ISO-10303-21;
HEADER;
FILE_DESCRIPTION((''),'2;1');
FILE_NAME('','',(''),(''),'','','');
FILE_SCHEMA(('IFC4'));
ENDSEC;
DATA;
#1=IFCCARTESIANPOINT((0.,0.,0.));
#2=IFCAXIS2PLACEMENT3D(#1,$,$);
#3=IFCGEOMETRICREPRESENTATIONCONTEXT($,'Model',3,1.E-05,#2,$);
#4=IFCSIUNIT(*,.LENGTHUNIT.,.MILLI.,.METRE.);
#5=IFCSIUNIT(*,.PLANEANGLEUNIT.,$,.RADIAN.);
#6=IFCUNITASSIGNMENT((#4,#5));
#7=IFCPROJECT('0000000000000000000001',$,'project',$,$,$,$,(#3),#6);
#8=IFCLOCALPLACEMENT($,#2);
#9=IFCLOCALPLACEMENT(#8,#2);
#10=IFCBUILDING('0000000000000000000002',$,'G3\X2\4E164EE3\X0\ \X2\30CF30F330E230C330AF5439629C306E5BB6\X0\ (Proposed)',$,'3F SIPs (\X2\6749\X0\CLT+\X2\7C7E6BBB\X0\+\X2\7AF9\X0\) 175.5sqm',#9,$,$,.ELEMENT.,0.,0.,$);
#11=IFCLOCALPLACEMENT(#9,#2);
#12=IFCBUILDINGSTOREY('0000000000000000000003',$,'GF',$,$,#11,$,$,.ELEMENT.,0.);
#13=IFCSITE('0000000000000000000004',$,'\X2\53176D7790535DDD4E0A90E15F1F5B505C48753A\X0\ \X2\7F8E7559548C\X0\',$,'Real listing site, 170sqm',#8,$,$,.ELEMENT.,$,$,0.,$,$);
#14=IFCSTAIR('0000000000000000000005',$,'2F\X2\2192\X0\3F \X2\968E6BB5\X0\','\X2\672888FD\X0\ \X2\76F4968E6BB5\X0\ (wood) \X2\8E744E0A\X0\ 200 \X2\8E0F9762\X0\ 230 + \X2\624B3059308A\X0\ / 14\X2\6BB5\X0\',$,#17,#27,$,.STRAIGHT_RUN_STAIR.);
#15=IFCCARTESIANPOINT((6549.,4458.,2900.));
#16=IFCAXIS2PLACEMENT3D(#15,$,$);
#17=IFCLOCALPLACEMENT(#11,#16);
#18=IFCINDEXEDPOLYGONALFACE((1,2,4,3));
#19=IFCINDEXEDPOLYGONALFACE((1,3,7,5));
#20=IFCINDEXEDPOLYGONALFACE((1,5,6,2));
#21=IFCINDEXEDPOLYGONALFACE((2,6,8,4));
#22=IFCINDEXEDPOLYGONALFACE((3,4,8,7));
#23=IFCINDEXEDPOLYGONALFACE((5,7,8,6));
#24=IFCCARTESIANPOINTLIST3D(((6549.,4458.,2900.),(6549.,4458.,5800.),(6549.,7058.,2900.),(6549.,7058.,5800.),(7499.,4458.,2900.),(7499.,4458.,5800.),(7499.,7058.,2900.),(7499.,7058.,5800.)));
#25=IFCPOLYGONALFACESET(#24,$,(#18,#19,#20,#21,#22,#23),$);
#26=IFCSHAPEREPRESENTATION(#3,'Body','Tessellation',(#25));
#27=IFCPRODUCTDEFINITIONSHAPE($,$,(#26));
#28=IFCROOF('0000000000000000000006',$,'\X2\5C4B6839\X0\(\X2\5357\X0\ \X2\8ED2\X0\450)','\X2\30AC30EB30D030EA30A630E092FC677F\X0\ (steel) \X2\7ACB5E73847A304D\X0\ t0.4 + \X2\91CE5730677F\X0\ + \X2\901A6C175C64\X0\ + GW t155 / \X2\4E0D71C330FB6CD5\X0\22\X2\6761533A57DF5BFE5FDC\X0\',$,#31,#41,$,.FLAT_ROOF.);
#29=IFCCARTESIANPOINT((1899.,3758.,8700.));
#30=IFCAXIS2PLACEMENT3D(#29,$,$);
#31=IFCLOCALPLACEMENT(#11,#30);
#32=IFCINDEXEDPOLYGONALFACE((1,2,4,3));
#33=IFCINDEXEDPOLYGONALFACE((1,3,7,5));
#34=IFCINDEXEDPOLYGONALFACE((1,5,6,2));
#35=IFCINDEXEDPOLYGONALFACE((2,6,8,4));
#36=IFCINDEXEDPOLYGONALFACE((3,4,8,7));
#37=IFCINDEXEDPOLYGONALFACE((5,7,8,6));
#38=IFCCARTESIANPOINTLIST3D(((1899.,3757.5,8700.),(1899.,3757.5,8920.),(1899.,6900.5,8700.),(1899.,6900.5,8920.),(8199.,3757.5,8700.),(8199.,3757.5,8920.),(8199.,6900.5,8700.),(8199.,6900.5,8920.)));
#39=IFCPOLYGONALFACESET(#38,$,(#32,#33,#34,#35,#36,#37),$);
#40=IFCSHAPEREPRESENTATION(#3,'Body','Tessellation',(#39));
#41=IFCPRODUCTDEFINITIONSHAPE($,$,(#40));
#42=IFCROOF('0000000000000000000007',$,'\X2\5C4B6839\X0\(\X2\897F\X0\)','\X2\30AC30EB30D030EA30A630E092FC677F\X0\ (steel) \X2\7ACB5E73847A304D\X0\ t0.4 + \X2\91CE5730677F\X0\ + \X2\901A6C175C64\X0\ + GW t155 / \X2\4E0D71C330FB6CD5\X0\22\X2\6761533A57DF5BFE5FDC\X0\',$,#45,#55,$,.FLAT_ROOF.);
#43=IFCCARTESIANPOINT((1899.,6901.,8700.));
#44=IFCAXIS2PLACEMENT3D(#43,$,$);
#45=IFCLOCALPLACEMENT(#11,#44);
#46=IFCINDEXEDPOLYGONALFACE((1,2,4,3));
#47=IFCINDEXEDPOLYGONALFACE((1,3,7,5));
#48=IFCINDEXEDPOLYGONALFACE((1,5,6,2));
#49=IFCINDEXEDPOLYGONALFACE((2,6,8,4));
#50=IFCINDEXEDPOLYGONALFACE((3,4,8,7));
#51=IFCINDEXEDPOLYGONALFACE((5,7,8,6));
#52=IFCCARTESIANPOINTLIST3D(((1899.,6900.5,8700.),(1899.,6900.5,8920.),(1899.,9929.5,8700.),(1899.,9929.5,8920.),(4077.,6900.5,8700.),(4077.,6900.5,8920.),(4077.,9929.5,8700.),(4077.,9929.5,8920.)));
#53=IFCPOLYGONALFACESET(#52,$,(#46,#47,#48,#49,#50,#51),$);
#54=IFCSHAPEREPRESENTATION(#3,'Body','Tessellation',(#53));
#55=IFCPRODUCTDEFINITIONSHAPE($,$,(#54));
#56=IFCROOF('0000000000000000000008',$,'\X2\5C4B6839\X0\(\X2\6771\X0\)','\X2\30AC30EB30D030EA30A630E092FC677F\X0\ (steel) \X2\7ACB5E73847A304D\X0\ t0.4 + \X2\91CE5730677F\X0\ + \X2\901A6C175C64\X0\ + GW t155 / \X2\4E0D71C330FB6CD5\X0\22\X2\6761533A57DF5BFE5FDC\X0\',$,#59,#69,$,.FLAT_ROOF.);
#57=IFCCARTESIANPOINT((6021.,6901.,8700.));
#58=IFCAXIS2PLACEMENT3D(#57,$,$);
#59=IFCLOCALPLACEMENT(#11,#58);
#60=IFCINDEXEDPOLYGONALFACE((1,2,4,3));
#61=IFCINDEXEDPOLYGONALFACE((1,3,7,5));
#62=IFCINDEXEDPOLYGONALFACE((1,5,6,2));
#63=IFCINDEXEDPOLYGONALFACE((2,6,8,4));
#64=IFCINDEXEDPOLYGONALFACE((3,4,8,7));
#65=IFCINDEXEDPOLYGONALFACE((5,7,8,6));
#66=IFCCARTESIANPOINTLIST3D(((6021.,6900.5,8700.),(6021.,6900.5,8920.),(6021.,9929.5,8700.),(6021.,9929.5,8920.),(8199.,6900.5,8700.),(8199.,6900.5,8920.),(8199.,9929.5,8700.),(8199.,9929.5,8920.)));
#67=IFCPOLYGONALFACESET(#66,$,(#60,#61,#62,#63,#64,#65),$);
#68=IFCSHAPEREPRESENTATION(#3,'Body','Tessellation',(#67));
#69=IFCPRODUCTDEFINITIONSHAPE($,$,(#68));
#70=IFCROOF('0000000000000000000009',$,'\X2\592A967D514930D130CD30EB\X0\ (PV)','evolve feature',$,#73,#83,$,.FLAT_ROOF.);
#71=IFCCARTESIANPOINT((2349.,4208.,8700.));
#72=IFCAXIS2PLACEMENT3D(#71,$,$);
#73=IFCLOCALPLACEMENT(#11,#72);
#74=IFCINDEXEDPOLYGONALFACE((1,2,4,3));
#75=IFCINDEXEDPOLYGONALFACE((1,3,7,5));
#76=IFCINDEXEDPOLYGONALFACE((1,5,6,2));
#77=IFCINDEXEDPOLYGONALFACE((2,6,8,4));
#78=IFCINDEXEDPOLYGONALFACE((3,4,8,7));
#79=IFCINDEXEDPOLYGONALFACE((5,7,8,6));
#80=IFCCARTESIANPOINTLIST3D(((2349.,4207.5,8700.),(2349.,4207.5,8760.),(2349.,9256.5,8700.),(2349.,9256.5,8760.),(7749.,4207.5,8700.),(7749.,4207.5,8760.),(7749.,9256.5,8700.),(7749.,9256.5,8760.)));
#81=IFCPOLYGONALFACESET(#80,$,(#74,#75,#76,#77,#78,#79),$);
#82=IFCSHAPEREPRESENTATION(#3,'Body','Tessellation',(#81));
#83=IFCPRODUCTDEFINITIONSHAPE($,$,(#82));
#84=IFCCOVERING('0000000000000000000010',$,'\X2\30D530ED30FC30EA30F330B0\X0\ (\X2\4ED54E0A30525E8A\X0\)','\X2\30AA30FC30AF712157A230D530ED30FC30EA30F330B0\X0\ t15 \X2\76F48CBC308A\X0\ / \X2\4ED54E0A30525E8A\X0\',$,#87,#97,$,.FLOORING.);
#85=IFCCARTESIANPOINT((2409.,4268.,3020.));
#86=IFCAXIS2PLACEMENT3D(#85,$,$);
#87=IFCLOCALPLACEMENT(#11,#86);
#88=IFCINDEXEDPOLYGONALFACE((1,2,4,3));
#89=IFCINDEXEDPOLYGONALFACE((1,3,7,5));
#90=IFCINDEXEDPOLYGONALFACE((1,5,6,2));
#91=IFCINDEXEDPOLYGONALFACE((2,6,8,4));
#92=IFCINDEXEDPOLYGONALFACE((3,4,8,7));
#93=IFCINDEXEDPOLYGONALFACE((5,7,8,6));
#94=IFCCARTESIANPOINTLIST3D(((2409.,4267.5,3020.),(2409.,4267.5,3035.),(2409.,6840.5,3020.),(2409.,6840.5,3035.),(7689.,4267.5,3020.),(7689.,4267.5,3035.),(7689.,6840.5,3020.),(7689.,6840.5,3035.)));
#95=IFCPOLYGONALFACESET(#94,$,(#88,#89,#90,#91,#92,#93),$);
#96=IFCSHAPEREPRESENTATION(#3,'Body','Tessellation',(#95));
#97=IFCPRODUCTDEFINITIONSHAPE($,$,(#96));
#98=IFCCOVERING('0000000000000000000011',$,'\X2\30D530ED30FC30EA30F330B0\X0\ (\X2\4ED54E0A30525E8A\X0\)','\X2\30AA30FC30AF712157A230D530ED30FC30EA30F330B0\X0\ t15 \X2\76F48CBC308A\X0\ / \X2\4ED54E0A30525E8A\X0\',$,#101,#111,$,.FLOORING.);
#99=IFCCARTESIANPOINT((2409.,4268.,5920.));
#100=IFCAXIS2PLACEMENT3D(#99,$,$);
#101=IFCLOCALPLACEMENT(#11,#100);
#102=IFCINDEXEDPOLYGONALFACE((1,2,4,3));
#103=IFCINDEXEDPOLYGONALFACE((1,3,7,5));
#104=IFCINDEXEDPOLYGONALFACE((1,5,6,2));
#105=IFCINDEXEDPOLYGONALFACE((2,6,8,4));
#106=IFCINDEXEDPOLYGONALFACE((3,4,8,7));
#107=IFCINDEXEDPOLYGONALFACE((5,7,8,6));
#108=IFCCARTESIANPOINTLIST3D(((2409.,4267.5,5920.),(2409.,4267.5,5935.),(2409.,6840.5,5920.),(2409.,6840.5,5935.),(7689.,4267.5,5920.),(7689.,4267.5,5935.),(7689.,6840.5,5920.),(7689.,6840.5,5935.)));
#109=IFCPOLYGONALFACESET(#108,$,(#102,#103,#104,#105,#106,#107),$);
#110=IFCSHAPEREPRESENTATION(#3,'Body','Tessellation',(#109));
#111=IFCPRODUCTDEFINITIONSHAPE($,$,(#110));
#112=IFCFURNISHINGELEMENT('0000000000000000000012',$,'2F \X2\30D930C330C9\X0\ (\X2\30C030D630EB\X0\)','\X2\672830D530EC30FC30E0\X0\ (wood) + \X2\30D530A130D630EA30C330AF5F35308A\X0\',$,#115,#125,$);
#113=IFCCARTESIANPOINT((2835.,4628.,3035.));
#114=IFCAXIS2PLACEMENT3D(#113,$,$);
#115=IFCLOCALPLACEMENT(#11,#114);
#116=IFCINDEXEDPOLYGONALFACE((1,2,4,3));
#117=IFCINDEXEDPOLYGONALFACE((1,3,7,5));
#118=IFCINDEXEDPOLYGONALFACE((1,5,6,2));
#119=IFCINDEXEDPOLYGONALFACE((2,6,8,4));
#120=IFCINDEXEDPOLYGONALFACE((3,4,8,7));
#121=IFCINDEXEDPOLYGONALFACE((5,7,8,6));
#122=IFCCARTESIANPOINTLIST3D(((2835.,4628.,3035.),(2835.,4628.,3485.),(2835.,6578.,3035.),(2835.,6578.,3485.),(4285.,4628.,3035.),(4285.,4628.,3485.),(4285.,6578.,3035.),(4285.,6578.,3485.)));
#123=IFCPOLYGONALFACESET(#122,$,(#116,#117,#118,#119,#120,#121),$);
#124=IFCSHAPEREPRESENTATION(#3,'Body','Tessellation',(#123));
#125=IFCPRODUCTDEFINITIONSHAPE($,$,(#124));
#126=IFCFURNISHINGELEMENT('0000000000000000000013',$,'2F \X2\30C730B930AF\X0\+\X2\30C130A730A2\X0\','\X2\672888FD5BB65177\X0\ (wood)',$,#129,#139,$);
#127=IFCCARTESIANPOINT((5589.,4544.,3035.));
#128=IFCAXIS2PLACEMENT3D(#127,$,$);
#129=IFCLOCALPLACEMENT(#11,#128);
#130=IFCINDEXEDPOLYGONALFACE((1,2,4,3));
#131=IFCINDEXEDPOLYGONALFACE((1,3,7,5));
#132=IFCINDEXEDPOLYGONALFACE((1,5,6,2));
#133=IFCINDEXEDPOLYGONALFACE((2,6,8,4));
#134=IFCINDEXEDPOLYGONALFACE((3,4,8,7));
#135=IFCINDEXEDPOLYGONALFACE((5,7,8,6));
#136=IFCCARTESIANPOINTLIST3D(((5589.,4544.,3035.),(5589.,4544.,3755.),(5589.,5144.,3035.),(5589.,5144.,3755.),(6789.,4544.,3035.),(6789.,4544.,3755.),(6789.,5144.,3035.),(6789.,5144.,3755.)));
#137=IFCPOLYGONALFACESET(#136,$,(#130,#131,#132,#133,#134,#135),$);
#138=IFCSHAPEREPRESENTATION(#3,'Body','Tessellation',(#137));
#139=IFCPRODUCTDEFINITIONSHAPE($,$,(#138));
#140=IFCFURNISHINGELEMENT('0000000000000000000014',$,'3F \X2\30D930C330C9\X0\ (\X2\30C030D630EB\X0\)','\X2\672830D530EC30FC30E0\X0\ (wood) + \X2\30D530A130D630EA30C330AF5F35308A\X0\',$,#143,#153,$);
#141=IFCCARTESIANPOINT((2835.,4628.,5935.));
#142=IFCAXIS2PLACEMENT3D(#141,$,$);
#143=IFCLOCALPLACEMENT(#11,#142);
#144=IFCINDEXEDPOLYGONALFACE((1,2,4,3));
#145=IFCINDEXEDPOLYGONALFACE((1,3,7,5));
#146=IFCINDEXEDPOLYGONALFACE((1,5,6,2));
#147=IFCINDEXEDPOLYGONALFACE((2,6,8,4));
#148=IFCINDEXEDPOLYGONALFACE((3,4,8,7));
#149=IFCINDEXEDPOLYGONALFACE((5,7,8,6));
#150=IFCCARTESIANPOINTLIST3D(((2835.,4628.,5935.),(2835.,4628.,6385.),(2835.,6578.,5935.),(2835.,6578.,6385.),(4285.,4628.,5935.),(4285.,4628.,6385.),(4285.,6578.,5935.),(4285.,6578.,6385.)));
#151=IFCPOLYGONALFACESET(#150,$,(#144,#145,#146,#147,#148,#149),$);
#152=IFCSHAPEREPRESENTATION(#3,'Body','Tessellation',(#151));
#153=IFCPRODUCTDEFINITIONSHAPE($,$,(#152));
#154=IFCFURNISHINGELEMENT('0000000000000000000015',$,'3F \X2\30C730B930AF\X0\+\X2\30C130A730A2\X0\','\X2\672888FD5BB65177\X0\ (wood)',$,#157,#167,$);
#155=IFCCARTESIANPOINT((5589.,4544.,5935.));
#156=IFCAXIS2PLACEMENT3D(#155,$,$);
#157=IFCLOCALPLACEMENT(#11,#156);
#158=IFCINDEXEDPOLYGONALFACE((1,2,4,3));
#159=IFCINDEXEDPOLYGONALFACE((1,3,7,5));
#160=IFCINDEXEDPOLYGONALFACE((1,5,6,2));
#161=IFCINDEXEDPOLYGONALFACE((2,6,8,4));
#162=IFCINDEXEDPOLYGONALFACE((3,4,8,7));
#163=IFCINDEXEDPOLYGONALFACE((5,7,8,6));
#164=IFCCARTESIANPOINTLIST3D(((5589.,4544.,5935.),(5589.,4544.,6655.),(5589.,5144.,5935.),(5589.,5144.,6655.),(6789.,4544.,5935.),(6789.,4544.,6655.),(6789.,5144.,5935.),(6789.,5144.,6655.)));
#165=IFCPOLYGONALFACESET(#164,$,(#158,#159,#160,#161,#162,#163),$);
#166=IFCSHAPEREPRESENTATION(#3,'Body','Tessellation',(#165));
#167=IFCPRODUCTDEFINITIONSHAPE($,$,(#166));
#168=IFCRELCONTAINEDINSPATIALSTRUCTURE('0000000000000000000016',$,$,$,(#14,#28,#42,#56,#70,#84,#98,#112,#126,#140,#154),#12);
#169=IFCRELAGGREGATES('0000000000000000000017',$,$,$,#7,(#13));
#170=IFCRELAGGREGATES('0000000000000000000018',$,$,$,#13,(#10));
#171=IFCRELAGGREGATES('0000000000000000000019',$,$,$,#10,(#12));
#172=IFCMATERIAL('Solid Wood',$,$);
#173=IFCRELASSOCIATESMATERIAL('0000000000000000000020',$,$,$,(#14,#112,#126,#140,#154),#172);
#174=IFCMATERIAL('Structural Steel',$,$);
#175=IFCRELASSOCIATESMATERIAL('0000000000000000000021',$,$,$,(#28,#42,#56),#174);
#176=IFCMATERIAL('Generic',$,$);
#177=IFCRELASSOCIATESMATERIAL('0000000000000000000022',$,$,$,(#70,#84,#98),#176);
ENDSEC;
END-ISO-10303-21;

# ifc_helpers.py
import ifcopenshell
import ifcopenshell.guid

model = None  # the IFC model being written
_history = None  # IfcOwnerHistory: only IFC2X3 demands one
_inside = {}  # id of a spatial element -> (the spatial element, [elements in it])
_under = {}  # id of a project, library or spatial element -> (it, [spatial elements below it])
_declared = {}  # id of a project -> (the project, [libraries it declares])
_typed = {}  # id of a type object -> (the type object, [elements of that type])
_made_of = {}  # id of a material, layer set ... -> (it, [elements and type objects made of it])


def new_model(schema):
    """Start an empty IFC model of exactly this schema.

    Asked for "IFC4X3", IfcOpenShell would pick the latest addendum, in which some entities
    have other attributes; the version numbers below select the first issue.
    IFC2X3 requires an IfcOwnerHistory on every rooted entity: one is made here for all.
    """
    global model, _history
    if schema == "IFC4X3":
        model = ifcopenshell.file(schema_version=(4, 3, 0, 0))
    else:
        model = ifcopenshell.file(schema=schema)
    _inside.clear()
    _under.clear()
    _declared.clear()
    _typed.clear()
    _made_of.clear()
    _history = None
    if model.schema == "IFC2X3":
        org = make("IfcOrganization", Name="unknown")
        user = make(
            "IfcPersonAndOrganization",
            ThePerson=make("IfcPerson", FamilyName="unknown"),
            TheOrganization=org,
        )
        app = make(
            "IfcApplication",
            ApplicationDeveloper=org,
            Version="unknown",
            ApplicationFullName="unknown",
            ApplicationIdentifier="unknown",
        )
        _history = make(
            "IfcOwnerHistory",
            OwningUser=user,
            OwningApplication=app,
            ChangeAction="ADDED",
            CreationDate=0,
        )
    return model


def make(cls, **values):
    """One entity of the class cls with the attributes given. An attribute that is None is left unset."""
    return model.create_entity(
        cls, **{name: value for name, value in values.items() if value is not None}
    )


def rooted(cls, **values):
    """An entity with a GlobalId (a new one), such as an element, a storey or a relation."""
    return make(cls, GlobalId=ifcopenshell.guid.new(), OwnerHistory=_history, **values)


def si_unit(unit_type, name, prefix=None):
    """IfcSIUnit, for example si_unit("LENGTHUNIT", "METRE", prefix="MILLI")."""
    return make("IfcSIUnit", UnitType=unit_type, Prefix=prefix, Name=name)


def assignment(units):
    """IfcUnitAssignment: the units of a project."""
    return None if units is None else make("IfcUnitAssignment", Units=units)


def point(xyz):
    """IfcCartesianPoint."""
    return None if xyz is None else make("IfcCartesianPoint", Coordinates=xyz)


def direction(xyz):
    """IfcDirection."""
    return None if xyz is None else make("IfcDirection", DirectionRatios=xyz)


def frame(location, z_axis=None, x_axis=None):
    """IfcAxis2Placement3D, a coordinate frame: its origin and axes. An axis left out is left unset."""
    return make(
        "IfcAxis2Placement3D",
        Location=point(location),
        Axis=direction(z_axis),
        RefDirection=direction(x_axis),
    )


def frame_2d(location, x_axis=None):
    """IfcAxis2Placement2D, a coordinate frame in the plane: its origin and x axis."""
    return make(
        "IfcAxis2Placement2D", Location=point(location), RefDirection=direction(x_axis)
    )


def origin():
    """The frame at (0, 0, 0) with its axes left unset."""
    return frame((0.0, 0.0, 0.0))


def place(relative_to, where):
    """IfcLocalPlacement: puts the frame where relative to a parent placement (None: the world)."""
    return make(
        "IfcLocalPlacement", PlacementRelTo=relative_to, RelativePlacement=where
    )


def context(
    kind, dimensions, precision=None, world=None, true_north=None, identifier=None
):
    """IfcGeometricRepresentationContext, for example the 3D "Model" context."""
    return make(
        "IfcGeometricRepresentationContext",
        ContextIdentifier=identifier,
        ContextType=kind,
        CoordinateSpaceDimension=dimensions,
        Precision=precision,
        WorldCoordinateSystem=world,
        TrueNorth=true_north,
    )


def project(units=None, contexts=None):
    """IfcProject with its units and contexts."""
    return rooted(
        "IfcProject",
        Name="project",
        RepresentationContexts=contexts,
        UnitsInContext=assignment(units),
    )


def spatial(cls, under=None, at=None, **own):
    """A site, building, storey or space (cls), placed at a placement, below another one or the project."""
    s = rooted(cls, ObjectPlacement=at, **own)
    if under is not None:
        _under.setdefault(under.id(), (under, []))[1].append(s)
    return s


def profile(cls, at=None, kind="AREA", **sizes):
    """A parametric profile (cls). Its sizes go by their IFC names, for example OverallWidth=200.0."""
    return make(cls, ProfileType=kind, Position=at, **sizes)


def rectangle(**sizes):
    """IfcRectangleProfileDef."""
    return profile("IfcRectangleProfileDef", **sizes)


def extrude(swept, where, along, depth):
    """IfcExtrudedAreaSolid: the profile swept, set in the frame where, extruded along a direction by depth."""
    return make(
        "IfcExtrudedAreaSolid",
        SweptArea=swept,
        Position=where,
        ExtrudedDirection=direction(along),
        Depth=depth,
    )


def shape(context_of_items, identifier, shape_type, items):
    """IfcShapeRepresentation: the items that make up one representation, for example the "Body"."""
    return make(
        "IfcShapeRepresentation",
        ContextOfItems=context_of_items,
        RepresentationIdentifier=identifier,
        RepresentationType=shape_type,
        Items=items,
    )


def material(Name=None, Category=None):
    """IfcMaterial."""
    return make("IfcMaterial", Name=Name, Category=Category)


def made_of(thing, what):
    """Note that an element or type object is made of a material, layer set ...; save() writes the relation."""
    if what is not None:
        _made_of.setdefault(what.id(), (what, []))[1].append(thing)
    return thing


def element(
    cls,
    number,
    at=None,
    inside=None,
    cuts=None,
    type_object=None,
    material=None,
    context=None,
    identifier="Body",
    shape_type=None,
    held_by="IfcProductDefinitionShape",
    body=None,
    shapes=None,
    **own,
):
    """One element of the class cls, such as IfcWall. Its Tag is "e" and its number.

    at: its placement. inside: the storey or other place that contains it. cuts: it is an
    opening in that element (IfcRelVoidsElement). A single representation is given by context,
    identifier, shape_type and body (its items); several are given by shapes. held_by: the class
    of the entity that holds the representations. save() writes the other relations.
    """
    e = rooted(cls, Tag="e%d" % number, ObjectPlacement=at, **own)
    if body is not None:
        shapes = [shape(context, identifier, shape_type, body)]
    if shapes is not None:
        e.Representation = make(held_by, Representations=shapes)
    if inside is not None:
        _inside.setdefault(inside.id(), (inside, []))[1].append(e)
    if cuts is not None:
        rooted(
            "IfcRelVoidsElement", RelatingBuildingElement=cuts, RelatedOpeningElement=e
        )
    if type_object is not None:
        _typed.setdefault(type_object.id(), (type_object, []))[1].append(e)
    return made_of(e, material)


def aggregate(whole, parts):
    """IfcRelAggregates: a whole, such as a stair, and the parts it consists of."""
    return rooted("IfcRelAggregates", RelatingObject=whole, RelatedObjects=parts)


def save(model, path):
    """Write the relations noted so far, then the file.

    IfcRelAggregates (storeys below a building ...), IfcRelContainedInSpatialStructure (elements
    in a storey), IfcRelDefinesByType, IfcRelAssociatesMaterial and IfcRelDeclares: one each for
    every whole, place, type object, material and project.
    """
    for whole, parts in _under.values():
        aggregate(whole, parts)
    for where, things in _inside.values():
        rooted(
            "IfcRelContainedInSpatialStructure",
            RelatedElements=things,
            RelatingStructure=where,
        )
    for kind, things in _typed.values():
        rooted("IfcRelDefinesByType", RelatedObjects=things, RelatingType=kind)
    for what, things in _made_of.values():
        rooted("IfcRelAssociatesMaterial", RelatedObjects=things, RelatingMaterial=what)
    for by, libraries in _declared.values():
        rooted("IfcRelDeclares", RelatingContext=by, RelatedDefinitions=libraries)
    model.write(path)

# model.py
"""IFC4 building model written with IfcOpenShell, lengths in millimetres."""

from ifc_helpers import new_model, si_unit, frame, frame_2d, origin, place, context, project, spatial, rectangle, extrude, material, element, save


model = new_model("IFC4")

# Units and contexts
model_context = context("Model", 3, precision=1e-05, world=origin())
ifc_project = project(units=[si_unit("LENGTHUNIT", "METRE", prefix="MILLI"), si_unit("PLANEANGLEUNIT", "RADIAN")], contexts=[model_context])

# Site, building, storey
site_placement = place(None, origin())
site = spatial("IfcSite", under=ifc_project, at=site_placement, Name="北海道川上郡弟子屈町 美留和", ObjectType="Real listing site, 170sqm", CompositionType="ELEMENT", RefElevation=0.0)
building_placement = place(site_placement, origin())
building = spatial("IfcBuilding", under=site, at=building_placement, Name="G3世代 ハンモック吹抜の家 (Proposed)", ObjectType="3F SIPs (杉CLT+籾殻+竹) 175.5sqm", CompositionType="ELEMENT", ElevationOfRefHeight=0.0, ElevationOfTerrain=0.0)
storey_placement = place(building_placement, origin())
storey = spatial("IfcBuildingStorey", under=building, at=storey_placement, Name="GF", CompositionType="ELEMENT", Elevation=0.0)

# Shared definitions
ifc_material_1 = material(Name="Solid Wood")

# Stair
stair_placement = place(storey_placement, frame((6549.0, 4458.0, 2900.0)))
element("IfcStair", 1, at=stair_placement, inside=storey, material=ifc_material_1, Name="2F→3F 階段", Description="木製 直階段 (wood) 蹴上 200 踏面 230 + 手すり / 14段", PredefinedType="STRAIGHT_RUN_STAIR", context=model_context, shape_type="SweptSolid", body=[
    extrude(rectangle(XDim=950.0, YDim=2600.0, at=frame_2d((475.0, 1300.0))), frame((6549.0, 4458.0, 2900.0)), (0.0, 0.0, 1.0), 2900.0),
])

# Roofs
ifc_material_2 = material(Name="Structural Steel")
roof_1_placement = place(storey_placement, frame((1899.0, 3758.0, 8700.0)))
element("IfcRoof", 2, at=roof_1_placement, inside=storey, material=ifc_material_2, Name="屋根(南 軒450)", Description="ガルバリウム鋼板 (steel) 立平葺き t0.4 + 野地板 + 通気層 + GW t155 / 不燃・法22条区域対応", PredefinedType="FLAT_ROOF", context=model_context, shape_type="SweptSolid", body=[
    extrude(rectangle(XDim=6300.0, YDim=3143.0, at=frame_2d((3150.0, 1571.0))), frame((1899.0, 3758.0, 8700.0)), (0.0, 0.0, 1.0), 220.0),
])
roof_2_placement = place(storey_placement, frame((1899.0, 6901.0, 8700.0)))
element("IfcRoof", 3, at=roof_2_placement, inside=storey, material=ifc_material_2, Name="屋根(西)", Description="ガルバリウム鋼板 (steel) 立平葺き t0.4 + 野地板 + 通気層 + GW t155 / 不燃・法22条区域対応", PredefinedType="FLAT_ROOF", context=model_context, shape_type="SweptSolid", body=[
    extrude(rectangle(XDim=2178.0, YDim=3029.0, at=frame_2d((1089.0, 1514.0))), frame((1899.0, 6901.0, 8700.0)), (0.0, 0.0, 1.0), 220.0),
])
roof_3_placement = place(storey_placement, frame((6021.0, 6901.0, 8700.0)))
element("IfcRoof", 4, at=roof_3_placement, inside=storey, material=ifc_material_2, Name="屋根(東)", Description="ガルバリウム鋼板 (steel) 立平葺き t0.4 + 野地板 + 通気層 + GW t155 / 不燃・法22条区域対応", PredefinedType="FLAT_ROOF", context=model_context, shape_type="SweptSolid", body=[
    extrude(rectangle(XDim=2178.0, YDim=3029.0, at=frame_2d((1089.0, 1514.0))), frame((6021.0, 6901.0, 8700.0)), (0.0, 0.0, 1.0), 220.0),
])
ifc_material_3 = material(Name="Generic")
roof_4_placement = place(storey_placement, frame((2349.0, 4208.0, 8700.0)))
element("IfcRoof", 5, at=roof_4_placement, inside=storey, material=ifc_material_3, Name="太陽光パネル (PV)", Description="evolve feature", PredefinedType="FLAT_ROOF", context=model_context, shape_type="SweptSolid", body=[
    extrude(rectangle(XDim=5400.0, YDim=5049.0, at=frame_2d((2700.0, 2524.0))), frame((2349.0, 4208.0, 8700.0)), (0.0, 0.0, 1.0), 60.0),
])

# Coverings
covering_1_placement = place(storey_placement, frame((2409.0, 4268.0, 3020.0)))
element("IfcCovering", 6, at=covering_1_placement, inside=storey, material=ifc_material_3, Name="フローリング (仕上げ床)", Description="オーク無垢フローリング t15 直貼り / 仕上げ床", PredefinedType="FLOORING", context=model_context, shape_type="SweptSolid", body=[
    extrude(rectangle(XDim=5280.0, YDim=2573.0, at=frame_2d((2640.0, 1286.0))), frame((2409.0, 4268.0, 3020.0)), (0.0, 0.0, 1.0), 15.0),
])
covering_2_placement = place(storey_placement, frame((2409.0, 4268.0, 5920.0)))
element("IfcCovering", 7, at=covering_2_placement, inside=storey, material=ifc_material_3, Name="フローリング (仕上げ床)", Description="オーク無垢フローリング t15 直貼り / 仕上げ床", PredefinedType="FLOORING", context=model_context, shape_type="SweptSolid", body=[
    extrude(rectangle(XDim=5280.0, YDim=2573.0, at=frame_2d((2640.0, 1286.0))), frame((2409.0, 4268.0, 5920.0)), (0.0, 0.0, 1.0), 15.0),
])

# Furnishing elements
furnishing_1_placement = place(storey_placement, frame((2835.0, 4628.0, 3035.0)))
element("IfcFurnishingElement", 8, at=furnishing_1_placement, inside=storey, material=ifc_material_1, Name="2F ベッド (ダブル)", Description="木フレーム (wood) + ファブリック張り", context=model_context, shape_type="SweptSolid", body=[
    extrude(rectangle(XDim=1450.0, YDim=1950.0, at=frame_2d((725.0, 975.0))), frame((2835.0, 4628.0, 3035.0)), (0.0, 0.0, 1.0), 450.0),
])
furnishing_2_placement = place(storey_placement, frame((5589.0, 4544.0, 3035.0)))
element("IfcFurnishingElement", 9, at=furnishing_2_placement, inside=storey, material=ifc_material_1, Name="2F デスク+チェア", Description="木製家具 (wood)", context=model_context, shape_type="SweptSolid", body=[
    extrude(rectangle(XDim=1200.0, YDim=600.0, at=frame_2d((600.0, 300.0))), frame((5589.0, 4544.0, 3035.0)), (0.0, 0.0, 1.0), 720.0),
])
furnishing_3_placement = place(storey_placement, frame((2835.0, 4628.0, 5935.0)))
element("IfcFurnishingElement", 10, at=furnishing_3_placement, inside=storey, material=ifc_material_1, Name="3F ベッド (ダブル)", Description="木フレーム (wood) + ファブリック張り", context=model_context, shape_type="SweptSolid", body=[
    extrude(rectangle(XDim=1450.0, YDim=1950.0, at=frame_2d((725.0, 975.0))), frame((2835.0, 4628.0, 5935.0)), (0.0, 0.0, 1.0), 450.0),
])
furnishing_4_placement = place(storey_placement, frame((5589.0, 4544.0, 5935.0)))
element("IfcFurnishingElement", 11, at=furnishing_4_placement, inside=storey, material=ifc_material_1, Name="3F デスク+チェア", Description="木製家具 (wood)", context=model_context, shape_type="SweptSolid", body=[
    extrude(rectangle(XDim=1200.0, YDim=600.0, at=frame_2d((600.0, 300.0))), frame((5589.0, 4544.0, 5935.0)), (0.0, 0.0, 1.0), 720.0),
])

save(model, "model.ifc")
